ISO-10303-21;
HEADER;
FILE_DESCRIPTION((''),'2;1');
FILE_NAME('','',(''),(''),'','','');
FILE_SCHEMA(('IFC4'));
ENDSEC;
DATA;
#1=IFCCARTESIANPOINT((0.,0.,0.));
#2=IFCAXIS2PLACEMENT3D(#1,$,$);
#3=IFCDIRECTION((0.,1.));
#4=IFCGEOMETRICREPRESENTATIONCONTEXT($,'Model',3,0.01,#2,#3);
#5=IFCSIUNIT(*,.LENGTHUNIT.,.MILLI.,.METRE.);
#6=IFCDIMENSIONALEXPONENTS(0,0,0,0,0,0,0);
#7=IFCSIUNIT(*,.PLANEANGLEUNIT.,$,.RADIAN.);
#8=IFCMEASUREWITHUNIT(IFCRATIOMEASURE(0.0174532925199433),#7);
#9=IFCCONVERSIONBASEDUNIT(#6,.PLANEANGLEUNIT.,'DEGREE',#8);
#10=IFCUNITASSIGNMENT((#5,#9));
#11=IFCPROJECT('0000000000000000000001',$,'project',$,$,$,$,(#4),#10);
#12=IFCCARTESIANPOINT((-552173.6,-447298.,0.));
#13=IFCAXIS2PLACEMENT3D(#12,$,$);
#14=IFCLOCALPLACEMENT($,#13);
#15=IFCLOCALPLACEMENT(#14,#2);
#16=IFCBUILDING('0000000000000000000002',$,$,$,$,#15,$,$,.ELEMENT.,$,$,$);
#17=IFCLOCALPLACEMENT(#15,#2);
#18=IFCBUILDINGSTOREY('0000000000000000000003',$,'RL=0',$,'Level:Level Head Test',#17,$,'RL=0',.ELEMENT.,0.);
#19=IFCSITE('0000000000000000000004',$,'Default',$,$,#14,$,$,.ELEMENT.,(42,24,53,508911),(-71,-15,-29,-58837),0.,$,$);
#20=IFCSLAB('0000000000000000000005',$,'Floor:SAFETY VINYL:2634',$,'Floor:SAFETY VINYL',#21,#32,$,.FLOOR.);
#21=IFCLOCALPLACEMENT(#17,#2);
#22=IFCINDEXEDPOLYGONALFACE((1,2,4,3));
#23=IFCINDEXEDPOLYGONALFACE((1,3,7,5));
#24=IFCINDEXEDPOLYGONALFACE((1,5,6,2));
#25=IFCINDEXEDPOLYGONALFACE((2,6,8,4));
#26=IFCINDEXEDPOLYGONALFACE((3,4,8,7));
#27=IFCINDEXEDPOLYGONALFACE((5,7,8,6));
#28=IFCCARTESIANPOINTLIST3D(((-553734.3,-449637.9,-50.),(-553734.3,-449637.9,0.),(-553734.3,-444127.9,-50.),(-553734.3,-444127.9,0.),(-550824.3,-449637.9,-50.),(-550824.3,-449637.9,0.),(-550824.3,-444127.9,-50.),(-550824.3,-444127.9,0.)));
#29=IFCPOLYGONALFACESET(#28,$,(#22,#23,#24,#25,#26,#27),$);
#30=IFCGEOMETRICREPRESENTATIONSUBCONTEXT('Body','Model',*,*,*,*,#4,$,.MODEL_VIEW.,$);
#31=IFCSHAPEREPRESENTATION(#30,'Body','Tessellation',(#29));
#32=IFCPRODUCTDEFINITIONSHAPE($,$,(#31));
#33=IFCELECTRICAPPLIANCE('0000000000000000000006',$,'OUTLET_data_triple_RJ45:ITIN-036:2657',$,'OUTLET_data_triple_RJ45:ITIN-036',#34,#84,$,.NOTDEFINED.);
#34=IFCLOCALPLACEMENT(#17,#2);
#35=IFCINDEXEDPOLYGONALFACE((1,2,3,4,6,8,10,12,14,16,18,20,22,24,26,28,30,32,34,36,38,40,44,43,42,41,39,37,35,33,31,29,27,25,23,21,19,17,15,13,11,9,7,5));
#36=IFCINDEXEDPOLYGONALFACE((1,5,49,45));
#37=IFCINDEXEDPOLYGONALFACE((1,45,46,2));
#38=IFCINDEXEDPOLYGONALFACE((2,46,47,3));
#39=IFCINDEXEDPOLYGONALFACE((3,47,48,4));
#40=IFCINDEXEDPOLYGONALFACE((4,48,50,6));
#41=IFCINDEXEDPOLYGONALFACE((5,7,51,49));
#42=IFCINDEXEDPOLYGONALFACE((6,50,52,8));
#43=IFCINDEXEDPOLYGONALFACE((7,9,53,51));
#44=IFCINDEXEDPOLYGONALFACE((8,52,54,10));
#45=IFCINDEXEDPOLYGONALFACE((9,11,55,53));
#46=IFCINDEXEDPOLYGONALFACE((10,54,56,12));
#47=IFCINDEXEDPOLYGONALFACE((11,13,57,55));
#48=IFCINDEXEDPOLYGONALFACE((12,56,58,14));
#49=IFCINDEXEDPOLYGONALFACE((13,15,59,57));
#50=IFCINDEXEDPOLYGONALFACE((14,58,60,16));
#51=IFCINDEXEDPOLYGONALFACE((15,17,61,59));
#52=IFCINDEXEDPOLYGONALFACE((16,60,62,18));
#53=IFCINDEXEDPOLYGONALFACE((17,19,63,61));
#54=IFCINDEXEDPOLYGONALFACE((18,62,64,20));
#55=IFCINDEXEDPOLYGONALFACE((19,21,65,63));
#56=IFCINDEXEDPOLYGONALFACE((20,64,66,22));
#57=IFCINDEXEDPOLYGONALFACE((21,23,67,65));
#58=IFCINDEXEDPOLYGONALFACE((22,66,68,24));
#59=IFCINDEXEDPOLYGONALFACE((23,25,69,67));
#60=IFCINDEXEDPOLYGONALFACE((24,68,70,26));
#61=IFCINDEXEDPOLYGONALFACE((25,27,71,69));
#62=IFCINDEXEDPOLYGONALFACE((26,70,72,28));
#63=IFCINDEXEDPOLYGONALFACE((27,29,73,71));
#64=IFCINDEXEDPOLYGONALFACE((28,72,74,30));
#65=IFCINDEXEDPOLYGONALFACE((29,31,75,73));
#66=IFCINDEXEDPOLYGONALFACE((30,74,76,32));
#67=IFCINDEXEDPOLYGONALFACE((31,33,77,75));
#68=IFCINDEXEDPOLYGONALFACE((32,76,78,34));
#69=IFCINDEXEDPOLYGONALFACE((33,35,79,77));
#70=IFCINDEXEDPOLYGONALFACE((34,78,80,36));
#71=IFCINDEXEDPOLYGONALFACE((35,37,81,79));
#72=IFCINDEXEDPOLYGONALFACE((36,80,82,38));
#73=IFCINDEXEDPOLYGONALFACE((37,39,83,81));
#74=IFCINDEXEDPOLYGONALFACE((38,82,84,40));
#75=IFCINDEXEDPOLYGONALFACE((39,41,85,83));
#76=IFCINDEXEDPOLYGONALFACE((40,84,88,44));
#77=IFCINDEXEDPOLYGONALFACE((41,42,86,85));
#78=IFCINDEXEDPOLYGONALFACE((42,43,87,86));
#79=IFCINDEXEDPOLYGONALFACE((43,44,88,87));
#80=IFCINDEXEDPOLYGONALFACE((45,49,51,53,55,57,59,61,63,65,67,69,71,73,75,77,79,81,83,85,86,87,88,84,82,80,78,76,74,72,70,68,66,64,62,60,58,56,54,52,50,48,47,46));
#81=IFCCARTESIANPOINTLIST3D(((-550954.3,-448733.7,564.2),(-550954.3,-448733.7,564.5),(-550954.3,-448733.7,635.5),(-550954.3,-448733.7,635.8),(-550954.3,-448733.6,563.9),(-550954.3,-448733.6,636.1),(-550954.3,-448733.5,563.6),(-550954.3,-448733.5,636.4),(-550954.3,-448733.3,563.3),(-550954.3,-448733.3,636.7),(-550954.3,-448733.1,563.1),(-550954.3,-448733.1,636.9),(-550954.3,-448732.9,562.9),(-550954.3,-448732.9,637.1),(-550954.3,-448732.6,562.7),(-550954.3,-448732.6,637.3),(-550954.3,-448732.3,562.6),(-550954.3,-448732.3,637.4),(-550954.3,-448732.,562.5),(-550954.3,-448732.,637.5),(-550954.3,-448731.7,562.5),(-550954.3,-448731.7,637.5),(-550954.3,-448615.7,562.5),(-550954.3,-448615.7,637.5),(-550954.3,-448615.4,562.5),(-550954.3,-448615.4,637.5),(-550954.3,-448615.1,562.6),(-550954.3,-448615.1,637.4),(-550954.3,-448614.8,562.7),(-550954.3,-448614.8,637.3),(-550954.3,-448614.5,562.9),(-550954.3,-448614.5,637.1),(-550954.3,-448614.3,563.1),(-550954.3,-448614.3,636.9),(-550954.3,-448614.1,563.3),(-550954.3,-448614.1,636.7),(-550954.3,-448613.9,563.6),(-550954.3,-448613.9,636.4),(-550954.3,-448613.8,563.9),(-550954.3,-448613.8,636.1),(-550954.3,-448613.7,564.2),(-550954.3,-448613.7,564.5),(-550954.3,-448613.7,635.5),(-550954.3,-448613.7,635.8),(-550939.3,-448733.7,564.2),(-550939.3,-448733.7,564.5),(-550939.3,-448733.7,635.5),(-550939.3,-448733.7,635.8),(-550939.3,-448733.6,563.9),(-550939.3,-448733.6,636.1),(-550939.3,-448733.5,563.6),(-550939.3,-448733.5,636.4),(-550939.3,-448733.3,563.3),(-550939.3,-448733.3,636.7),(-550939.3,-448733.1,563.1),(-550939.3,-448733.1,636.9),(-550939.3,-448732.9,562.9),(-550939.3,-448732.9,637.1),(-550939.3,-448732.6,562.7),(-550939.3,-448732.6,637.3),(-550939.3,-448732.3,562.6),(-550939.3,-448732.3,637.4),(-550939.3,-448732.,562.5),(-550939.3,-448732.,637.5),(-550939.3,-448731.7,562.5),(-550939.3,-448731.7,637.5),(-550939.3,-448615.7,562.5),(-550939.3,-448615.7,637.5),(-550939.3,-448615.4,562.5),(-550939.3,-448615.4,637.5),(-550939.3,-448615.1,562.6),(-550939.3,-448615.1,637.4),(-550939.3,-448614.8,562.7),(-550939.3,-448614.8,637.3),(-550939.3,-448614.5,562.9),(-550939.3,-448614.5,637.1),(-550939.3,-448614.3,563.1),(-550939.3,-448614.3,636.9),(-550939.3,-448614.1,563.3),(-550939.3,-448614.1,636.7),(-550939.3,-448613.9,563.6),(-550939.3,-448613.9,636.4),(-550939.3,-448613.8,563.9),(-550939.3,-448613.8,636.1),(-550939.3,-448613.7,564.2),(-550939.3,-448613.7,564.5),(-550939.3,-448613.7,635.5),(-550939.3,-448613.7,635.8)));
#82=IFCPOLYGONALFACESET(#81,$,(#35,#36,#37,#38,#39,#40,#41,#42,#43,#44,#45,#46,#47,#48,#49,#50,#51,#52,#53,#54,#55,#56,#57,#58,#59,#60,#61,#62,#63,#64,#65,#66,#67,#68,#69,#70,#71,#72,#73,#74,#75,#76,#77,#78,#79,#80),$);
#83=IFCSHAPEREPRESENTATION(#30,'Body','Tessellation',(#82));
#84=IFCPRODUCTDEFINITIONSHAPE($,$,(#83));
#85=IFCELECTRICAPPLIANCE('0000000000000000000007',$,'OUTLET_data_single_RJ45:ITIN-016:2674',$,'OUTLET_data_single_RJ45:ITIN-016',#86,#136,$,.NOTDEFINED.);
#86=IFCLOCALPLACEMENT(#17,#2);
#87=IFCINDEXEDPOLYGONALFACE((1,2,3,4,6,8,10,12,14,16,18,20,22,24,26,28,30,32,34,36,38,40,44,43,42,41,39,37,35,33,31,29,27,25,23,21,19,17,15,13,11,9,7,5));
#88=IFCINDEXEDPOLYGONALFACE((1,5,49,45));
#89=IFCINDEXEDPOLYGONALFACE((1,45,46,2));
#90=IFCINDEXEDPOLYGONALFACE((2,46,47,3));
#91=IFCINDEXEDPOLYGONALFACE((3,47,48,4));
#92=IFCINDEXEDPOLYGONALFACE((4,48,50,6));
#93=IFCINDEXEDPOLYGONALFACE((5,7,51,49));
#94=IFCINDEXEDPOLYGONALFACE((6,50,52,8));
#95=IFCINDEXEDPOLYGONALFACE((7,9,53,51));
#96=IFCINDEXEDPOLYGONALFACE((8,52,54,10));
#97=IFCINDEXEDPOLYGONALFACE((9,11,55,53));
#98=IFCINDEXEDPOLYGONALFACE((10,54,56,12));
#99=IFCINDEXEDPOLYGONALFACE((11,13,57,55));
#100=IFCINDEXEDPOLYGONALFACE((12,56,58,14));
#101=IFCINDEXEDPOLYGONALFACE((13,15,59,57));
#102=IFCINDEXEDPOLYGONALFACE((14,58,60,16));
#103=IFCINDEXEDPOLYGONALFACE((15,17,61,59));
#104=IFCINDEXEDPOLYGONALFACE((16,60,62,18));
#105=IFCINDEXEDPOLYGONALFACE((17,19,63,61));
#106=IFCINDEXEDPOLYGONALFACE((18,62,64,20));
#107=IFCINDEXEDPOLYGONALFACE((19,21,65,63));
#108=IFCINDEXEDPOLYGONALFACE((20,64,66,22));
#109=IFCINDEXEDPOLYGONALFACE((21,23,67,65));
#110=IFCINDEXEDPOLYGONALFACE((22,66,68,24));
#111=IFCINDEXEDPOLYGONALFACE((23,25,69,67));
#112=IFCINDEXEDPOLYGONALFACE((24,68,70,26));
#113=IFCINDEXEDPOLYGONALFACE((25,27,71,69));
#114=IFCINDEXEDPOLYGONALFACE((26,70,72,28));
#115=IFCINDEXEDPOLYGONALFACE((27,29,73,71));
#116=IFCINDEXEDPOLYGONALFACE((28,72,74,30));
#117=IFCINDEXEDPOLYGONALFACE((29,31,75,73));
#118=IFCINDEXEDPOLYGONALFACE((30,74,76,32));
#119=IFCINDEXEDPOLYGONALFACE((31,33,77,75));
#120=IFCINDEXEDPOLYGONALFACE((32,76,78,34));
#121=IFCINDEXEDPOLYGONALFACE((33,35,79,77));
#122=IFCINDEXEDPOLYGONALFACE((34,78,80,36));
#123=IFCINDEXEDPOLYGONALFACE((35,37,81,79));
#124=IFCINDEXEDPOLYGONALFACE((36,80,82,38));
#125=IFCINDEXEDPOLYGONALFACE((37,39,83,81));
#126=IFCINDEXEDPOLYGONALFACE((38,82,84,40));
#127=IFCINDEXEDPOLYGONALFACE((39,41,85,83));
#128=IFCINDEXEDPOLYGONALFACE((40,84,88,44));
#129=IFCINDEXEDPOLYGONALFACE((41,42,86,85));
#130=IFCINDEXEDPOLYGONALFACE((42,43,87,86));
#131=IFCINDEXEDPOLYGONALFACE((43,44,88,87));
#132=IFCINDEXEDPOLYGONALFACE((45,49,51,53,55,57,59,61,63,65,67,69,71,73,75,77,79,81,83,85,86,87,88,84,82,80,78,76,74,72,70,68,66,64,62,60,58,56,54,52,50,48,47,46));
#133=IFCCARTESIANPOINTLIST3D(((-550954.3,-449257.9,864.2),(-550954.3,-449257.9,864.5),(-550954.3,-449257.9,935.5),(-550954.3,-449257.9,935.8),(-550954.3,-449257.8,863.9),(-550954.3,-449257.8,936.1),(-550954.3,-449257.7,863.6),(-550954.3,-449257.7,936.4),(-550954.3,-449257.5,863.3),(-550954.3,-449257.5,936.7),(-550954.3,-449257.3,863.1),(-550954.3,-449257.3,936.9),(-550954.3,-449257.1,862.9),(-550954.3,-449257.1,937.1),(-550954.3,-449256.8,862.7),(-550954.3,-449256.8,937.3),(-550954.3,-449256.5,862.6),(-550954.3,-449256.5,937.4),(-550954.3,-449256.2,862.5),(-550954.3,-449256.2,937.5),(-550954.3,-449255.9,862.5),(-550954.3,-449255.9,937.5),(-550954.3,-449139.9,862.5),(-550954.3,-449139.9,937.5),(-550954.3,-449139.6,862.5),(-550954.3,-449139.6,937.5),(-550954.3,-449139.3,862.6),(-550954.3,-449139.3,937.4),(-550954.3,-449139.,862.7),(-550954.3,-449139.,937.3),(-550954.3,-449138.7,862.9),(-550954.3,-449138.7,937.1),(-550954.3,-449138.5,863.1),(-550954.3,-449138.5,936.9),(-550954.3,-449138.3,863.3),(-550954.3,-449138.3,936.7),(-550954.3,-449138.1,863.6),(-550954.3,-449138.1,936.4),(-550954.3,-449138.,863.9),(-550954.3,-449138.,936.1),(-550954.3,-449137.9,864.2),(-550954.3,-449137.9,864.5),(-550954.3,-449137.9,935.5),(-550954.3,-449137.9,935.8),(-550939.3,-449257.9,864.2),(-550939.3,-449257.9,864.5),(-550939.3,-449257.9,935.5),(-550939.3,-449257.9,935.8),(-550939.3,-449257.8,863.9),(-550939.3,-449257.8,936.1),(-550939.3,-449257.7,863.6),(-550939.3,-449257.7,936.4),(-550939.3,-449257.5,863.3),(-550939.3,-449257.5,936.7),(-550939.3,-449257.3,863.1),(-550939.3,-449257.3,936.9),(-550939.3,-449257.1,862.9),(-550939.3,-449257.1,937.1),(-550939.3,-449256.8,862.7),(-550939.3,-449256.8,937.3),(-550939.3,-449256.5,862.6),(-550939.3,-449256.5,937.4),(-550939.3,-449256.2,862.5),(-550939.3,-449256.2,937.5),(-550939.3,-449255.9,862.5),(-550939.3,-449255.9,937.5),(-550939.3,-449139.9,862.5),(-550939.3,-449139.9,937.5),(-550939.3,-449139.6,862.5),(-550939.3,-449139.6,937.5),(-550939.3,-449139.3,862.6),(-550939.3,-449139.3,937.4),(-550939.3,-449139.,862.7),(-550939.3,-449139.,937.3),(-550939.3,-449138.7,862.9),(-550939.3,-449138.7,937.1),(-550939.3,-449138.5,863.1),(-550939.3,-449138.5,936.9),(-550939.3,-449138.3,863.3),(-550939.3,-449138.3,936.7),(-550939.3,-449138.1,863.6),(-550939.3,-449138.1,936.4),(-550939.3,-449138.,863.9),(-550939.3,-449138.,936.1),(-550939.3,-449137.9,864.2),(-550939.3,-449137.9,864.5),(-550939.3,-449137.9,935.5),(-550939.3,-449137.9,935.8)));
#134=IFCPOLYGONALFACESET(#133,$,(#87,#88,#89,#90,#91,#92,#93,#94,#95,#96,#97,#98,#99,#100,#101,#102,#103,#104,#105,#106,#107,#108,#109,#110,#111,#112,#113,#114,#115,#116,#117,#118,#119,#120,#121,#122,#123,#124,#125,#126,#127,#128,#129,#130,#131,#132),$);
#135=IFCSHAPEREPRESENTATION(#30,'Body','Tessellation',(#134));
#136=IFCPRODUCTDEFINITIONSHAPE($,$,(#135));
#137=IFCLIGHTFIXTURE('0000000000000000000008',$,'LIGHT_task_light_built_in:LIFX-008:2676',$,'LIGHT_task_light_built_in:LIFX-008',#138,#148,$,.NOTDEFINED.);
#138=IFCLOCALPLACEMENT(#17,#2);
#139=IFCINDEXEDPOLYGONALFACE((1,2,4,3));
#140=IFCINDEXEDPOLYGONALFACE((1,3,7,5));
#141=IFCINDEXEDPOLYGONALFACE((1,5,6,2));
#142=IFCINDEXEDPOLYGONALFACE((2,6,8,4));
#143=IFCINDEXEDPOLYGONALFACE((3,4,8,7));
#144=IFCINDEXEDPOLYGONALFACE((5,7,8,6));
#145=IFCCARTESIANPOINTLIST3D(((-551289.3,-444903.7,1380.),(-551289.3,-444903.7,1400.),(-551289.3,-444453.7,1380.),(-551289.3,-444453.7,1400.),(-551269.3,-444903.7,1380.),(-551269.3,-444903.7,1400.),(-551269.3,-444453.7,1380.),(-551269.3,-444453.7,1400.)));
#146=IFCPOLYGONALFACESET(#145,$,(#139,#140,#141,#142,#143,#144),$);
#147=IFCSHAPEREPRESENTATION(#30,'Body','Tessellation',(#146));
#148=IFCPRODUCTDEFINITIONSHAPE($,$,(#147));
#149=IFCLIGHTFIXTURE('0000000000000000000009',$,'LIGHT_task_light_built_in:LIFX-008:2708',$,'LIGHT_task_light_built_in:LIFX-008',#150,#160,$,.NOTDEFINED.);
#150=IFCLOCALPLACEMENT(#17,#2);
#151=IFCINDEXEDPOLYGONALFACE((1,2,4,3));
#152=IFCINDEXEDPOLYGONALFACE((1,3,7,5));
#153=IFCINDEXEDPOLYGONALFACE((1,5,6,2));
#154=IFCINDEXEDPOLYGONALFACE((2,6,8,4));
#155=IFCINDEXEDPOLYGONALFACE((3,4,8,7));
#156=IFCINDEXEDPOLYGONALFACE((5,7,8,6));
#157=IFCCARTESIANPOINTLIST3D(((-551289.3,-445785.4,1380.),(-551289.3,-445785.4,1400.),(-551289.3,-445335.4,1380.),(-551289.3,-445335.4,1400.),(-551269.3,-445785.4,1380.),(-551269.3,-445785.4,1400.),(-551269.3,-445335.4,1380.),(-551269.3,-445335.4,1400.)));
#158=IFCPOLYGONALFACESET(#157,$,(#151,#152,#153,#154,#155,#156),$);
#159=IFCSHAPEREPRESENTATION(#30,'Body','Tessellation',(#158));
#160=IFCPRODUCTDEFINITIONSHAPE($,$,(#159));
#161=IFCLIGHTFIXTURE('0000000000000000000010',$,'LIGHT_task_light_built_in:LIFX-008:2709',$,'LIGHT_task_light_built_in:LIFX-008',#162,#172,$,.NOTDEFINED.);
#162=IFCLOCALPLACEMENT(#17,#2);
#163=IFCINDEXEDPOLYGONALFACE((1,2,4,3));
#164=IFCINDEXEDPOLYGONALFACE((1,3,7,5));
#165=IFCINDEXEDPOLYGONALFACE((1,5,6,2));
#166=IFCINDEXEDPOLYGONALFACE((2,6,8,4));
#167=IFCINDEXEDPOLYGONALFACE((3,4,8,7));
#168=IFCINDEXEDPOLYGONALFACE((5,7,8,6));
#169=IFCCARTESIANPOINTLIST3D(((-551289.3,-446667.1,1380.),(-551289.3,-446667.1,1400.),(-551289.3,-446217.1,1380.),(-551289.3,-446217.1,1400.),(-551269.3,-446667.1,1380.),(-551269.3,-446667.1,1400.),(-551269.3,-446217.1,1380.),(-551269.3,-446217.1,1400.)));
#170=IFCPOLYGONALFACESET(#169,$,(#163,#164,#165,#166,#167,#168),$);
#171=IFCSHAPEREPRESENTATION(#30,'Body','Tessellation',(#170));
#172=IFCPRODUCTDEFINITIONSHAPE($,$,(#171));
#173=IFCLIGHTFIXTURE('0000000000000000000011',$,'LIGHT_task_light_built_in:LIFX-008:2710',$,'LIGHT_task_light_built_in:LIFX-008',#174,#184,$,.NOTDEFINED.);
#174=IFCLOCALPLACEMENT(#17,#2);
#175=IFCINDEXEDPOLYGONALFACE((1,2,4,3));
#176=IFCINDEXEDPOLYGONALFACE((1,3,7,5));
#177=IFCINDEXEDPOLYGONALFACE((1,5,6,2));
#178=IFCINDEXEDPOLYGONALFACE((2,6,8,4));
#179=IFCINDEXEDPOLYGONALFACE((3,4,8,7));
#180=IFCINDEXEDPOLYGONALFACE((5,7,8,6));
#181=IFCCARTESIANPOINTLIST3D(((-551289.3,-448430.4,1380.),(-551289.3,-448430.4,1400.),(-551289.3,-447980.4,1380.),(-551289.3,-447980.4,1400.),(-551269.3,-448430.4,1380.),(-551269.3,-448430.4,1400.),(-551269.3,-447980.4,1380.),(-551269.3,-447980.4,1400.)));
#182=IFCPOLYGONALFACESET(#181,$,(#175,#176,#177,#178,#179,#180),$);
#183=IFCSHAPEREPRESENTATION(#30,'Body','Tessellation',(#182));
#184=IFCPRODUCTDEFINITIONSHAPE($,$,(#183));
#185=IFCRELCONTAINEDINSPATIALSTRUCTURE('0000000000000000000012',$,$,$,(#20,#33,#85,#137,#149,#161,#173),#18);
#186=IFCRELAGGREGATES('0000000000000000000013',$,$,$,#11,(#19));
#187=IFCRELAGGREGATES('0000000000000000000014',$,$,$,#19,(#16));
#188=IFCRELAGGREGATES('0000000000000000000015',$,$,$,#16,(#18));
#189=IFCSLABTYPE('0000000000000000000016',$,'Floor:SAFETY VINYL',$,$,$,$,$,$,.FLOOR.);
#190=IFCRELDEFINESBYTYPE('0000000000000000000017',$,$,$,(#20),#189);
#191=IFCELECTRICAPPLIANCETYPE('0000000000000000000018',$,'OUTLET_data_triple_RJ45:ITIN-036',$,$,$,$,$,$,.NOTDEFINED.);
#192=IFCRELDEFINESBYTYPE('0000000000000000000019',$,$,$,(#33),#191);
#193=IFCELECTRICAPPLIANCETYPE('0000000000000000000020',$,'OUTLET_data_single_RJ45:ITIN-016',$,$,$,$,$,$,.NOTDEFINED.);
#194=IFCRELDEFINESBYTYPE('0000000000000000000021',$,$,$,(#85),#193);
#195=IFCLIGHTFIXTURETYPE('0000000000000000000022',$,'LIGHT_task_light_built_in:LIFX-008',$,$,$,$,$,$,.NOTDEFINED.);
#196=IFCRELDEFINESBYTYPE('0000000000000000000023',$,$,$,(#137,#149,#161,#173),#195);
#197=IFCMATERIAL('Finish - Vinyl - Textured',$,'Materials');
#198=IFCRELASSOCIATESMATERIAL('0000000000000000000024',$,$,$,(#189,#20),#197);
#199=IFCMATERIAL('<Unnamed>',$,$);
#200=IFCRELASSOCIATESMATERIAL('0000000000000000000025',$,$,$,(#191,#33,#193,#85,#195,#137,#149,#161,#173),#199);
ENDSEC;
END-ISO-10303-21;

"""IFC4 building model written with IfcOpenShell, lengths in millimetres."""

from ifc_helpers import new_model, entity, si_unit, converted_unit, direction, frame, origin, place, context, subcontext, project, spatial, indexed_curve, outline, extrude, source, transform, mapped, material, type_object, type_shapes, element, save


model = new_model("IFC4")

# Units and contexts
model_context = context("Model", 3, precision=0.01, world=origin(), true_north=direction((0.0, 1.0)))
body_context = subcontext(model_context, "Body", "Model", "MODEL_VIEW")
ifc_project = project(units=[si_unit("LENGTHUNIT", "METRE", prefix="MILLI"), converted_unit("PLANEANGLEUNIT", "DEGREE", entity("IfcRatioMeasure", 0.0174532925199433), si_unit("PLANEANGLEUNIT", "RADIAN"), dimensions=[0, 0, 0, 0, 0, 0, 0])], contexts=[model_context])

# Site, building, storey
site_placement = place(None, frame((-552173.6, -447298.0, 0.0)))
site = spatial("IfcSite", under=ifc_project, at=site_placement, Name="Default", CompositionType="ELEMENT", RefLatitude=(42, 24, 53, 508911), RefLongitude=(-71, -15, -29, -58837), RefElevation=0.0)
building_placement = place(site_placement, origin())
building = spatial("IfcBuilding", under=site, at=building_placement, CompositionType="ELEMENT")
storey_placement = place(building_placement, origin())
storey = spatial("IfcBuildingStorey", under=building, at=storey_placement, Name="RL=0", ObjectType="Level:Level Head Test", LongName="RL=0", CompositionType="ELEMENT", Elevation=0.0)

# Slab
ifc_material_1 = material(Name="Finish - Vinyl - Textured", Category="Materials")
slab_type = type_object("IfcSlabType", Name="Floor:SAFETY VINYL", PredefinedType="FLOOR", material=ifc_material_1)
slab_placement = place(storey_placement, origin())
element("IfcSlab", 1, at=slab_placement, inside=storey, type_object=slab_type, material=ifc_material_1, Name="Floor:SAFETY VINYL:2634", ObjectType="Floor:SAFETY VINYL", PredefinedType="FLOOR", context=body_context, shape_type="SweptSolid", body=[
    extrude(outline(indexed_curve([(-2755.0, -1455.0), (2755.0, -1455.0), (2755.0, 1455.0), (-2755.0, 1455.0), (-2755.0, -1455.0)], self_intersect=False)), frame((-552279.3, -446882.9, 0.0), z_axis=(0.0, 0.0, -1.0), x_axis=(0.0, 1.0, 0.0)), (0.0, 0.0, 1.0), 50.0),
])

# Electric appliances
ifc_material_2 = material(Name="<Unnamed>")
electric_appliance_type_1 = type_object("IfcElectricApplianceType", Name="OUTLET_data_triple_RJ45:ITIN-036", PredefinedType="NOTDEFINED", material=ifc_material_2)
shared_shape_1 = source(origin(), body_context, "Body", "SweptSolid", [
    extrude(outline(indexed_curve([(-35.5, -60.0), (35.5, -60.0), (35.8, -60.0), (36.1, -59.9), (36.4, -59.8), (36.7, -59.6), (36.9, -59.4), (37.1, -59.2), (37.3, -58.9), (37.4, -58.6), (37.5, -58.3), (37.5, -58.0), (37.5, 58.0), (37.5, 58.3), (37.4, 58.6), (37.3, 58.9), (37.1, 59.2), (36.9, 59.4), (36.7, 59.6), (36.4, 59.8), (36.1, 59.9), (35.8, 60.0), (35.5, 60.0), (-35.5, 60.0), (-35.8, 60.0), (-36.1, 59.9), (-36.4, 59.8), (-36.7, 59.6), (-36.9, 59.4), (-37.1, 59.2), (-37.3, 58.9), (-37.4, 58.6), (-37.5, 58.3), (-37.5, 58.0), (-37.5, -58.0), (-37.5, -58.3), (-37.4, -58.6), (-37.3, -58.9), (-37.1, -59.2), (-36.9, -59.4), (-36.7, -59.6), (-36.4, -59.8), (-36.1, -59.9), (-35.8, -60.0), (-35.5, -60.0)], self_intersect=False)), frame((0.0, 0.0, 0.0), z_axis=(0.0, 1.0, 0.0), x_axis=(0.0, 0.0, 1.0)), (0.0, 0.0, 1.0), 15.0),
])
type_shapes(electric_appliance_type_1, [shared_shape_1])
electric_appliance_1_placement = place(storey_placement, frame((-550954.3, -448673.7, 600.0), z_axis=(0.0, 0.0, 1.0), x_axis=(0.0, -1.0, 0.0)))
element("IfcElectricAppliance", 2, at=electric_appliance_1_placement, inside=storey, type_object=electric_appliance_type_1, material=ifc_material_2, Name="OUTLET_data_triple_RJ45:ITIN-036:2657", ObjectType="OUTLET_data_triple_RJ45:ITIN-036", PredefinedType="NOTDEFINED", context=body_context, shape_type="MappedRepresentation", body=[
    mapped(shared_shape_1, transform((0.0, 0.0, 0.0), scale=1.0)),
])
electric_appliance_type_2 = type_object("IfcElectricApplianceType", Name="OUTLET_data_single_RJ45:ITIN-016", PredefinedType="NOTDEFINED", material=ifc_material_2)
shared_shape_2 = source(origin(), body_context, "Body", "SweptSolid", [
    extrude(outline(indexed_curve([(-35.5, -60.0), (35.5, -60.0), (35.8, -60.0), (36.1, -59.9), (36.4, -59.8), (36.7, -59.6), (36.9, -59.4), (37.1, -59.2), (37.3, -58.9), (37.4, -58.6), (37.5, -58.3), (37.5, -58.0), (37.5, 58.0), (37.5, 58.3), (37.4, 58.6), (37.3, 58.9), (37.1, 59.2), (36.9, 59.4), (36.7, 59.6), (36.4, 59.8), (36.1, 59.9), (35.8, 60.0), (35.5, 60.0), (-35.5, 60.0), (-35.8, 60.0), (-36.1, 59.9), (-36.4, 59.8), (-36.7, 59.6), (-36.9, 59.4), (-37.1, 59.2), (-37.3, 58.9), (-37.4, 58.6), (-37.5, 58.3), (-37.5, 58.0), (-37.5, -58.0), (-37.5, -58.3), (-37.4, -58.6), (-37.3, -58.9), (-37.1, -59.2), (-36.9, -59.4), (-36.7, -59.6), (-36.4, -59.8), (-36.1, -59.9), (-35.8, -60.0), (-35.5, -60.0)], self_intersect=False)), frame((0.0, -15.0, 0.0), z_axis=(0.0, 1.0, 0.0), x_axis=(0.0, 0.0, 1.0)), (0.0, 0.0, 1.0), 15.0),
])
type_shapes(electric_appliance_type_2, [shared_shape_2])
electric_appliance_2_placement = place(storey_placement, frame((-550939.3, -449197.9, 900.0), z_axis=(0.0, 0.0, 1.0), x_axis=(0.0, -1.0, 0.0)))
element("IfcElectricAppliance", 3, at=electric_appliance_2_placement, inside=storey, type_object=electric_appliance_type_2, material=ifc_material_2, Name="OUTLET_data_single_RJ45:ITIN-016:2674", ObjectType="OUTLET_data_single_RJ45:ITIN-016", PredefinedType="NOTDEFINED", context=body_context, shape_type="MappedRepresentation", body=[
    mapped(shared_shape_2, transform((0.0, 0.0, 0.0), scale=1.0)),
])

# Light fixtures
light_fixture_type = type_object("IfcLightFixtureType", Name="LIGHT_task_light_built_in:LIFX-008", PredefinedType="NOTDEFINED", material=ifc_material_2)
shared_shape_3 = source(origin(), body_context, "Body", "SweptSolid", [
    extrude(outline(indexed_curve([(-225.0, -10.0), (225.0, -10.0), (225.0, 10.0), (-225.0, 10.0), (-225.0, -10.0)], self_intersect=False)), frame((0.0, 0.0, 0.0), z_axis=(0.0, 0.0, 1.0), x_axis=(-1.0, 0.0, 0.0)), (0.0, 0.0, 1.0), 20.0),
])
type_shapes(light_fixture_type, [shared_shape_3])
for number, where, z_axis, x_axis, name in (
    (4, (-551279.3, -444678.7, 1380.0), (0.0, 0.0, 1.0), (0.0, 1.0, 0.0), "LIGHT_task_light_built_in:LIFX-008:2676"),
    (5, (-551279.3, -445560.4, 1380.0), (0.0, 0.0, 1.0), (0.0, 1.0, 0.0), "LIGHT_task_light_built_in:LIFX-008:2708"),
    (6, (-551279.3, -446442.1, 1380.0), (0.0, 0.0, 1.0), (0.0, 1.0, 0.0), "LIGHT_task_light_built_in:LIFX-008:2709"),
    (7, (-551279.3, -448205.4, 1380.0), (0.0, 0.0, 1.0), (0.0, 1.0, 0.0), "LIGHT_task_light_built_in:LIFX-008:2710"),
):
    element("IfcLightFixture", number, at=place(storey_placement, frame(where, z_axis=z_axis, x_axis=x_axis)), inside=storey, type_object=light_fixture_type, material=ifc_material_2, Name=name, ObjectType="LIGHT_task_light_built_in:LIFX-008", PredefinedType="NOTDEFINED", context=body_context, shape_type="MappedRepresentation", body=[
        mapped(shared_shape_3, transform((0.0, 0.0, 0.0), scale=1.0)),
    ])

save(model, "model.ifc")
